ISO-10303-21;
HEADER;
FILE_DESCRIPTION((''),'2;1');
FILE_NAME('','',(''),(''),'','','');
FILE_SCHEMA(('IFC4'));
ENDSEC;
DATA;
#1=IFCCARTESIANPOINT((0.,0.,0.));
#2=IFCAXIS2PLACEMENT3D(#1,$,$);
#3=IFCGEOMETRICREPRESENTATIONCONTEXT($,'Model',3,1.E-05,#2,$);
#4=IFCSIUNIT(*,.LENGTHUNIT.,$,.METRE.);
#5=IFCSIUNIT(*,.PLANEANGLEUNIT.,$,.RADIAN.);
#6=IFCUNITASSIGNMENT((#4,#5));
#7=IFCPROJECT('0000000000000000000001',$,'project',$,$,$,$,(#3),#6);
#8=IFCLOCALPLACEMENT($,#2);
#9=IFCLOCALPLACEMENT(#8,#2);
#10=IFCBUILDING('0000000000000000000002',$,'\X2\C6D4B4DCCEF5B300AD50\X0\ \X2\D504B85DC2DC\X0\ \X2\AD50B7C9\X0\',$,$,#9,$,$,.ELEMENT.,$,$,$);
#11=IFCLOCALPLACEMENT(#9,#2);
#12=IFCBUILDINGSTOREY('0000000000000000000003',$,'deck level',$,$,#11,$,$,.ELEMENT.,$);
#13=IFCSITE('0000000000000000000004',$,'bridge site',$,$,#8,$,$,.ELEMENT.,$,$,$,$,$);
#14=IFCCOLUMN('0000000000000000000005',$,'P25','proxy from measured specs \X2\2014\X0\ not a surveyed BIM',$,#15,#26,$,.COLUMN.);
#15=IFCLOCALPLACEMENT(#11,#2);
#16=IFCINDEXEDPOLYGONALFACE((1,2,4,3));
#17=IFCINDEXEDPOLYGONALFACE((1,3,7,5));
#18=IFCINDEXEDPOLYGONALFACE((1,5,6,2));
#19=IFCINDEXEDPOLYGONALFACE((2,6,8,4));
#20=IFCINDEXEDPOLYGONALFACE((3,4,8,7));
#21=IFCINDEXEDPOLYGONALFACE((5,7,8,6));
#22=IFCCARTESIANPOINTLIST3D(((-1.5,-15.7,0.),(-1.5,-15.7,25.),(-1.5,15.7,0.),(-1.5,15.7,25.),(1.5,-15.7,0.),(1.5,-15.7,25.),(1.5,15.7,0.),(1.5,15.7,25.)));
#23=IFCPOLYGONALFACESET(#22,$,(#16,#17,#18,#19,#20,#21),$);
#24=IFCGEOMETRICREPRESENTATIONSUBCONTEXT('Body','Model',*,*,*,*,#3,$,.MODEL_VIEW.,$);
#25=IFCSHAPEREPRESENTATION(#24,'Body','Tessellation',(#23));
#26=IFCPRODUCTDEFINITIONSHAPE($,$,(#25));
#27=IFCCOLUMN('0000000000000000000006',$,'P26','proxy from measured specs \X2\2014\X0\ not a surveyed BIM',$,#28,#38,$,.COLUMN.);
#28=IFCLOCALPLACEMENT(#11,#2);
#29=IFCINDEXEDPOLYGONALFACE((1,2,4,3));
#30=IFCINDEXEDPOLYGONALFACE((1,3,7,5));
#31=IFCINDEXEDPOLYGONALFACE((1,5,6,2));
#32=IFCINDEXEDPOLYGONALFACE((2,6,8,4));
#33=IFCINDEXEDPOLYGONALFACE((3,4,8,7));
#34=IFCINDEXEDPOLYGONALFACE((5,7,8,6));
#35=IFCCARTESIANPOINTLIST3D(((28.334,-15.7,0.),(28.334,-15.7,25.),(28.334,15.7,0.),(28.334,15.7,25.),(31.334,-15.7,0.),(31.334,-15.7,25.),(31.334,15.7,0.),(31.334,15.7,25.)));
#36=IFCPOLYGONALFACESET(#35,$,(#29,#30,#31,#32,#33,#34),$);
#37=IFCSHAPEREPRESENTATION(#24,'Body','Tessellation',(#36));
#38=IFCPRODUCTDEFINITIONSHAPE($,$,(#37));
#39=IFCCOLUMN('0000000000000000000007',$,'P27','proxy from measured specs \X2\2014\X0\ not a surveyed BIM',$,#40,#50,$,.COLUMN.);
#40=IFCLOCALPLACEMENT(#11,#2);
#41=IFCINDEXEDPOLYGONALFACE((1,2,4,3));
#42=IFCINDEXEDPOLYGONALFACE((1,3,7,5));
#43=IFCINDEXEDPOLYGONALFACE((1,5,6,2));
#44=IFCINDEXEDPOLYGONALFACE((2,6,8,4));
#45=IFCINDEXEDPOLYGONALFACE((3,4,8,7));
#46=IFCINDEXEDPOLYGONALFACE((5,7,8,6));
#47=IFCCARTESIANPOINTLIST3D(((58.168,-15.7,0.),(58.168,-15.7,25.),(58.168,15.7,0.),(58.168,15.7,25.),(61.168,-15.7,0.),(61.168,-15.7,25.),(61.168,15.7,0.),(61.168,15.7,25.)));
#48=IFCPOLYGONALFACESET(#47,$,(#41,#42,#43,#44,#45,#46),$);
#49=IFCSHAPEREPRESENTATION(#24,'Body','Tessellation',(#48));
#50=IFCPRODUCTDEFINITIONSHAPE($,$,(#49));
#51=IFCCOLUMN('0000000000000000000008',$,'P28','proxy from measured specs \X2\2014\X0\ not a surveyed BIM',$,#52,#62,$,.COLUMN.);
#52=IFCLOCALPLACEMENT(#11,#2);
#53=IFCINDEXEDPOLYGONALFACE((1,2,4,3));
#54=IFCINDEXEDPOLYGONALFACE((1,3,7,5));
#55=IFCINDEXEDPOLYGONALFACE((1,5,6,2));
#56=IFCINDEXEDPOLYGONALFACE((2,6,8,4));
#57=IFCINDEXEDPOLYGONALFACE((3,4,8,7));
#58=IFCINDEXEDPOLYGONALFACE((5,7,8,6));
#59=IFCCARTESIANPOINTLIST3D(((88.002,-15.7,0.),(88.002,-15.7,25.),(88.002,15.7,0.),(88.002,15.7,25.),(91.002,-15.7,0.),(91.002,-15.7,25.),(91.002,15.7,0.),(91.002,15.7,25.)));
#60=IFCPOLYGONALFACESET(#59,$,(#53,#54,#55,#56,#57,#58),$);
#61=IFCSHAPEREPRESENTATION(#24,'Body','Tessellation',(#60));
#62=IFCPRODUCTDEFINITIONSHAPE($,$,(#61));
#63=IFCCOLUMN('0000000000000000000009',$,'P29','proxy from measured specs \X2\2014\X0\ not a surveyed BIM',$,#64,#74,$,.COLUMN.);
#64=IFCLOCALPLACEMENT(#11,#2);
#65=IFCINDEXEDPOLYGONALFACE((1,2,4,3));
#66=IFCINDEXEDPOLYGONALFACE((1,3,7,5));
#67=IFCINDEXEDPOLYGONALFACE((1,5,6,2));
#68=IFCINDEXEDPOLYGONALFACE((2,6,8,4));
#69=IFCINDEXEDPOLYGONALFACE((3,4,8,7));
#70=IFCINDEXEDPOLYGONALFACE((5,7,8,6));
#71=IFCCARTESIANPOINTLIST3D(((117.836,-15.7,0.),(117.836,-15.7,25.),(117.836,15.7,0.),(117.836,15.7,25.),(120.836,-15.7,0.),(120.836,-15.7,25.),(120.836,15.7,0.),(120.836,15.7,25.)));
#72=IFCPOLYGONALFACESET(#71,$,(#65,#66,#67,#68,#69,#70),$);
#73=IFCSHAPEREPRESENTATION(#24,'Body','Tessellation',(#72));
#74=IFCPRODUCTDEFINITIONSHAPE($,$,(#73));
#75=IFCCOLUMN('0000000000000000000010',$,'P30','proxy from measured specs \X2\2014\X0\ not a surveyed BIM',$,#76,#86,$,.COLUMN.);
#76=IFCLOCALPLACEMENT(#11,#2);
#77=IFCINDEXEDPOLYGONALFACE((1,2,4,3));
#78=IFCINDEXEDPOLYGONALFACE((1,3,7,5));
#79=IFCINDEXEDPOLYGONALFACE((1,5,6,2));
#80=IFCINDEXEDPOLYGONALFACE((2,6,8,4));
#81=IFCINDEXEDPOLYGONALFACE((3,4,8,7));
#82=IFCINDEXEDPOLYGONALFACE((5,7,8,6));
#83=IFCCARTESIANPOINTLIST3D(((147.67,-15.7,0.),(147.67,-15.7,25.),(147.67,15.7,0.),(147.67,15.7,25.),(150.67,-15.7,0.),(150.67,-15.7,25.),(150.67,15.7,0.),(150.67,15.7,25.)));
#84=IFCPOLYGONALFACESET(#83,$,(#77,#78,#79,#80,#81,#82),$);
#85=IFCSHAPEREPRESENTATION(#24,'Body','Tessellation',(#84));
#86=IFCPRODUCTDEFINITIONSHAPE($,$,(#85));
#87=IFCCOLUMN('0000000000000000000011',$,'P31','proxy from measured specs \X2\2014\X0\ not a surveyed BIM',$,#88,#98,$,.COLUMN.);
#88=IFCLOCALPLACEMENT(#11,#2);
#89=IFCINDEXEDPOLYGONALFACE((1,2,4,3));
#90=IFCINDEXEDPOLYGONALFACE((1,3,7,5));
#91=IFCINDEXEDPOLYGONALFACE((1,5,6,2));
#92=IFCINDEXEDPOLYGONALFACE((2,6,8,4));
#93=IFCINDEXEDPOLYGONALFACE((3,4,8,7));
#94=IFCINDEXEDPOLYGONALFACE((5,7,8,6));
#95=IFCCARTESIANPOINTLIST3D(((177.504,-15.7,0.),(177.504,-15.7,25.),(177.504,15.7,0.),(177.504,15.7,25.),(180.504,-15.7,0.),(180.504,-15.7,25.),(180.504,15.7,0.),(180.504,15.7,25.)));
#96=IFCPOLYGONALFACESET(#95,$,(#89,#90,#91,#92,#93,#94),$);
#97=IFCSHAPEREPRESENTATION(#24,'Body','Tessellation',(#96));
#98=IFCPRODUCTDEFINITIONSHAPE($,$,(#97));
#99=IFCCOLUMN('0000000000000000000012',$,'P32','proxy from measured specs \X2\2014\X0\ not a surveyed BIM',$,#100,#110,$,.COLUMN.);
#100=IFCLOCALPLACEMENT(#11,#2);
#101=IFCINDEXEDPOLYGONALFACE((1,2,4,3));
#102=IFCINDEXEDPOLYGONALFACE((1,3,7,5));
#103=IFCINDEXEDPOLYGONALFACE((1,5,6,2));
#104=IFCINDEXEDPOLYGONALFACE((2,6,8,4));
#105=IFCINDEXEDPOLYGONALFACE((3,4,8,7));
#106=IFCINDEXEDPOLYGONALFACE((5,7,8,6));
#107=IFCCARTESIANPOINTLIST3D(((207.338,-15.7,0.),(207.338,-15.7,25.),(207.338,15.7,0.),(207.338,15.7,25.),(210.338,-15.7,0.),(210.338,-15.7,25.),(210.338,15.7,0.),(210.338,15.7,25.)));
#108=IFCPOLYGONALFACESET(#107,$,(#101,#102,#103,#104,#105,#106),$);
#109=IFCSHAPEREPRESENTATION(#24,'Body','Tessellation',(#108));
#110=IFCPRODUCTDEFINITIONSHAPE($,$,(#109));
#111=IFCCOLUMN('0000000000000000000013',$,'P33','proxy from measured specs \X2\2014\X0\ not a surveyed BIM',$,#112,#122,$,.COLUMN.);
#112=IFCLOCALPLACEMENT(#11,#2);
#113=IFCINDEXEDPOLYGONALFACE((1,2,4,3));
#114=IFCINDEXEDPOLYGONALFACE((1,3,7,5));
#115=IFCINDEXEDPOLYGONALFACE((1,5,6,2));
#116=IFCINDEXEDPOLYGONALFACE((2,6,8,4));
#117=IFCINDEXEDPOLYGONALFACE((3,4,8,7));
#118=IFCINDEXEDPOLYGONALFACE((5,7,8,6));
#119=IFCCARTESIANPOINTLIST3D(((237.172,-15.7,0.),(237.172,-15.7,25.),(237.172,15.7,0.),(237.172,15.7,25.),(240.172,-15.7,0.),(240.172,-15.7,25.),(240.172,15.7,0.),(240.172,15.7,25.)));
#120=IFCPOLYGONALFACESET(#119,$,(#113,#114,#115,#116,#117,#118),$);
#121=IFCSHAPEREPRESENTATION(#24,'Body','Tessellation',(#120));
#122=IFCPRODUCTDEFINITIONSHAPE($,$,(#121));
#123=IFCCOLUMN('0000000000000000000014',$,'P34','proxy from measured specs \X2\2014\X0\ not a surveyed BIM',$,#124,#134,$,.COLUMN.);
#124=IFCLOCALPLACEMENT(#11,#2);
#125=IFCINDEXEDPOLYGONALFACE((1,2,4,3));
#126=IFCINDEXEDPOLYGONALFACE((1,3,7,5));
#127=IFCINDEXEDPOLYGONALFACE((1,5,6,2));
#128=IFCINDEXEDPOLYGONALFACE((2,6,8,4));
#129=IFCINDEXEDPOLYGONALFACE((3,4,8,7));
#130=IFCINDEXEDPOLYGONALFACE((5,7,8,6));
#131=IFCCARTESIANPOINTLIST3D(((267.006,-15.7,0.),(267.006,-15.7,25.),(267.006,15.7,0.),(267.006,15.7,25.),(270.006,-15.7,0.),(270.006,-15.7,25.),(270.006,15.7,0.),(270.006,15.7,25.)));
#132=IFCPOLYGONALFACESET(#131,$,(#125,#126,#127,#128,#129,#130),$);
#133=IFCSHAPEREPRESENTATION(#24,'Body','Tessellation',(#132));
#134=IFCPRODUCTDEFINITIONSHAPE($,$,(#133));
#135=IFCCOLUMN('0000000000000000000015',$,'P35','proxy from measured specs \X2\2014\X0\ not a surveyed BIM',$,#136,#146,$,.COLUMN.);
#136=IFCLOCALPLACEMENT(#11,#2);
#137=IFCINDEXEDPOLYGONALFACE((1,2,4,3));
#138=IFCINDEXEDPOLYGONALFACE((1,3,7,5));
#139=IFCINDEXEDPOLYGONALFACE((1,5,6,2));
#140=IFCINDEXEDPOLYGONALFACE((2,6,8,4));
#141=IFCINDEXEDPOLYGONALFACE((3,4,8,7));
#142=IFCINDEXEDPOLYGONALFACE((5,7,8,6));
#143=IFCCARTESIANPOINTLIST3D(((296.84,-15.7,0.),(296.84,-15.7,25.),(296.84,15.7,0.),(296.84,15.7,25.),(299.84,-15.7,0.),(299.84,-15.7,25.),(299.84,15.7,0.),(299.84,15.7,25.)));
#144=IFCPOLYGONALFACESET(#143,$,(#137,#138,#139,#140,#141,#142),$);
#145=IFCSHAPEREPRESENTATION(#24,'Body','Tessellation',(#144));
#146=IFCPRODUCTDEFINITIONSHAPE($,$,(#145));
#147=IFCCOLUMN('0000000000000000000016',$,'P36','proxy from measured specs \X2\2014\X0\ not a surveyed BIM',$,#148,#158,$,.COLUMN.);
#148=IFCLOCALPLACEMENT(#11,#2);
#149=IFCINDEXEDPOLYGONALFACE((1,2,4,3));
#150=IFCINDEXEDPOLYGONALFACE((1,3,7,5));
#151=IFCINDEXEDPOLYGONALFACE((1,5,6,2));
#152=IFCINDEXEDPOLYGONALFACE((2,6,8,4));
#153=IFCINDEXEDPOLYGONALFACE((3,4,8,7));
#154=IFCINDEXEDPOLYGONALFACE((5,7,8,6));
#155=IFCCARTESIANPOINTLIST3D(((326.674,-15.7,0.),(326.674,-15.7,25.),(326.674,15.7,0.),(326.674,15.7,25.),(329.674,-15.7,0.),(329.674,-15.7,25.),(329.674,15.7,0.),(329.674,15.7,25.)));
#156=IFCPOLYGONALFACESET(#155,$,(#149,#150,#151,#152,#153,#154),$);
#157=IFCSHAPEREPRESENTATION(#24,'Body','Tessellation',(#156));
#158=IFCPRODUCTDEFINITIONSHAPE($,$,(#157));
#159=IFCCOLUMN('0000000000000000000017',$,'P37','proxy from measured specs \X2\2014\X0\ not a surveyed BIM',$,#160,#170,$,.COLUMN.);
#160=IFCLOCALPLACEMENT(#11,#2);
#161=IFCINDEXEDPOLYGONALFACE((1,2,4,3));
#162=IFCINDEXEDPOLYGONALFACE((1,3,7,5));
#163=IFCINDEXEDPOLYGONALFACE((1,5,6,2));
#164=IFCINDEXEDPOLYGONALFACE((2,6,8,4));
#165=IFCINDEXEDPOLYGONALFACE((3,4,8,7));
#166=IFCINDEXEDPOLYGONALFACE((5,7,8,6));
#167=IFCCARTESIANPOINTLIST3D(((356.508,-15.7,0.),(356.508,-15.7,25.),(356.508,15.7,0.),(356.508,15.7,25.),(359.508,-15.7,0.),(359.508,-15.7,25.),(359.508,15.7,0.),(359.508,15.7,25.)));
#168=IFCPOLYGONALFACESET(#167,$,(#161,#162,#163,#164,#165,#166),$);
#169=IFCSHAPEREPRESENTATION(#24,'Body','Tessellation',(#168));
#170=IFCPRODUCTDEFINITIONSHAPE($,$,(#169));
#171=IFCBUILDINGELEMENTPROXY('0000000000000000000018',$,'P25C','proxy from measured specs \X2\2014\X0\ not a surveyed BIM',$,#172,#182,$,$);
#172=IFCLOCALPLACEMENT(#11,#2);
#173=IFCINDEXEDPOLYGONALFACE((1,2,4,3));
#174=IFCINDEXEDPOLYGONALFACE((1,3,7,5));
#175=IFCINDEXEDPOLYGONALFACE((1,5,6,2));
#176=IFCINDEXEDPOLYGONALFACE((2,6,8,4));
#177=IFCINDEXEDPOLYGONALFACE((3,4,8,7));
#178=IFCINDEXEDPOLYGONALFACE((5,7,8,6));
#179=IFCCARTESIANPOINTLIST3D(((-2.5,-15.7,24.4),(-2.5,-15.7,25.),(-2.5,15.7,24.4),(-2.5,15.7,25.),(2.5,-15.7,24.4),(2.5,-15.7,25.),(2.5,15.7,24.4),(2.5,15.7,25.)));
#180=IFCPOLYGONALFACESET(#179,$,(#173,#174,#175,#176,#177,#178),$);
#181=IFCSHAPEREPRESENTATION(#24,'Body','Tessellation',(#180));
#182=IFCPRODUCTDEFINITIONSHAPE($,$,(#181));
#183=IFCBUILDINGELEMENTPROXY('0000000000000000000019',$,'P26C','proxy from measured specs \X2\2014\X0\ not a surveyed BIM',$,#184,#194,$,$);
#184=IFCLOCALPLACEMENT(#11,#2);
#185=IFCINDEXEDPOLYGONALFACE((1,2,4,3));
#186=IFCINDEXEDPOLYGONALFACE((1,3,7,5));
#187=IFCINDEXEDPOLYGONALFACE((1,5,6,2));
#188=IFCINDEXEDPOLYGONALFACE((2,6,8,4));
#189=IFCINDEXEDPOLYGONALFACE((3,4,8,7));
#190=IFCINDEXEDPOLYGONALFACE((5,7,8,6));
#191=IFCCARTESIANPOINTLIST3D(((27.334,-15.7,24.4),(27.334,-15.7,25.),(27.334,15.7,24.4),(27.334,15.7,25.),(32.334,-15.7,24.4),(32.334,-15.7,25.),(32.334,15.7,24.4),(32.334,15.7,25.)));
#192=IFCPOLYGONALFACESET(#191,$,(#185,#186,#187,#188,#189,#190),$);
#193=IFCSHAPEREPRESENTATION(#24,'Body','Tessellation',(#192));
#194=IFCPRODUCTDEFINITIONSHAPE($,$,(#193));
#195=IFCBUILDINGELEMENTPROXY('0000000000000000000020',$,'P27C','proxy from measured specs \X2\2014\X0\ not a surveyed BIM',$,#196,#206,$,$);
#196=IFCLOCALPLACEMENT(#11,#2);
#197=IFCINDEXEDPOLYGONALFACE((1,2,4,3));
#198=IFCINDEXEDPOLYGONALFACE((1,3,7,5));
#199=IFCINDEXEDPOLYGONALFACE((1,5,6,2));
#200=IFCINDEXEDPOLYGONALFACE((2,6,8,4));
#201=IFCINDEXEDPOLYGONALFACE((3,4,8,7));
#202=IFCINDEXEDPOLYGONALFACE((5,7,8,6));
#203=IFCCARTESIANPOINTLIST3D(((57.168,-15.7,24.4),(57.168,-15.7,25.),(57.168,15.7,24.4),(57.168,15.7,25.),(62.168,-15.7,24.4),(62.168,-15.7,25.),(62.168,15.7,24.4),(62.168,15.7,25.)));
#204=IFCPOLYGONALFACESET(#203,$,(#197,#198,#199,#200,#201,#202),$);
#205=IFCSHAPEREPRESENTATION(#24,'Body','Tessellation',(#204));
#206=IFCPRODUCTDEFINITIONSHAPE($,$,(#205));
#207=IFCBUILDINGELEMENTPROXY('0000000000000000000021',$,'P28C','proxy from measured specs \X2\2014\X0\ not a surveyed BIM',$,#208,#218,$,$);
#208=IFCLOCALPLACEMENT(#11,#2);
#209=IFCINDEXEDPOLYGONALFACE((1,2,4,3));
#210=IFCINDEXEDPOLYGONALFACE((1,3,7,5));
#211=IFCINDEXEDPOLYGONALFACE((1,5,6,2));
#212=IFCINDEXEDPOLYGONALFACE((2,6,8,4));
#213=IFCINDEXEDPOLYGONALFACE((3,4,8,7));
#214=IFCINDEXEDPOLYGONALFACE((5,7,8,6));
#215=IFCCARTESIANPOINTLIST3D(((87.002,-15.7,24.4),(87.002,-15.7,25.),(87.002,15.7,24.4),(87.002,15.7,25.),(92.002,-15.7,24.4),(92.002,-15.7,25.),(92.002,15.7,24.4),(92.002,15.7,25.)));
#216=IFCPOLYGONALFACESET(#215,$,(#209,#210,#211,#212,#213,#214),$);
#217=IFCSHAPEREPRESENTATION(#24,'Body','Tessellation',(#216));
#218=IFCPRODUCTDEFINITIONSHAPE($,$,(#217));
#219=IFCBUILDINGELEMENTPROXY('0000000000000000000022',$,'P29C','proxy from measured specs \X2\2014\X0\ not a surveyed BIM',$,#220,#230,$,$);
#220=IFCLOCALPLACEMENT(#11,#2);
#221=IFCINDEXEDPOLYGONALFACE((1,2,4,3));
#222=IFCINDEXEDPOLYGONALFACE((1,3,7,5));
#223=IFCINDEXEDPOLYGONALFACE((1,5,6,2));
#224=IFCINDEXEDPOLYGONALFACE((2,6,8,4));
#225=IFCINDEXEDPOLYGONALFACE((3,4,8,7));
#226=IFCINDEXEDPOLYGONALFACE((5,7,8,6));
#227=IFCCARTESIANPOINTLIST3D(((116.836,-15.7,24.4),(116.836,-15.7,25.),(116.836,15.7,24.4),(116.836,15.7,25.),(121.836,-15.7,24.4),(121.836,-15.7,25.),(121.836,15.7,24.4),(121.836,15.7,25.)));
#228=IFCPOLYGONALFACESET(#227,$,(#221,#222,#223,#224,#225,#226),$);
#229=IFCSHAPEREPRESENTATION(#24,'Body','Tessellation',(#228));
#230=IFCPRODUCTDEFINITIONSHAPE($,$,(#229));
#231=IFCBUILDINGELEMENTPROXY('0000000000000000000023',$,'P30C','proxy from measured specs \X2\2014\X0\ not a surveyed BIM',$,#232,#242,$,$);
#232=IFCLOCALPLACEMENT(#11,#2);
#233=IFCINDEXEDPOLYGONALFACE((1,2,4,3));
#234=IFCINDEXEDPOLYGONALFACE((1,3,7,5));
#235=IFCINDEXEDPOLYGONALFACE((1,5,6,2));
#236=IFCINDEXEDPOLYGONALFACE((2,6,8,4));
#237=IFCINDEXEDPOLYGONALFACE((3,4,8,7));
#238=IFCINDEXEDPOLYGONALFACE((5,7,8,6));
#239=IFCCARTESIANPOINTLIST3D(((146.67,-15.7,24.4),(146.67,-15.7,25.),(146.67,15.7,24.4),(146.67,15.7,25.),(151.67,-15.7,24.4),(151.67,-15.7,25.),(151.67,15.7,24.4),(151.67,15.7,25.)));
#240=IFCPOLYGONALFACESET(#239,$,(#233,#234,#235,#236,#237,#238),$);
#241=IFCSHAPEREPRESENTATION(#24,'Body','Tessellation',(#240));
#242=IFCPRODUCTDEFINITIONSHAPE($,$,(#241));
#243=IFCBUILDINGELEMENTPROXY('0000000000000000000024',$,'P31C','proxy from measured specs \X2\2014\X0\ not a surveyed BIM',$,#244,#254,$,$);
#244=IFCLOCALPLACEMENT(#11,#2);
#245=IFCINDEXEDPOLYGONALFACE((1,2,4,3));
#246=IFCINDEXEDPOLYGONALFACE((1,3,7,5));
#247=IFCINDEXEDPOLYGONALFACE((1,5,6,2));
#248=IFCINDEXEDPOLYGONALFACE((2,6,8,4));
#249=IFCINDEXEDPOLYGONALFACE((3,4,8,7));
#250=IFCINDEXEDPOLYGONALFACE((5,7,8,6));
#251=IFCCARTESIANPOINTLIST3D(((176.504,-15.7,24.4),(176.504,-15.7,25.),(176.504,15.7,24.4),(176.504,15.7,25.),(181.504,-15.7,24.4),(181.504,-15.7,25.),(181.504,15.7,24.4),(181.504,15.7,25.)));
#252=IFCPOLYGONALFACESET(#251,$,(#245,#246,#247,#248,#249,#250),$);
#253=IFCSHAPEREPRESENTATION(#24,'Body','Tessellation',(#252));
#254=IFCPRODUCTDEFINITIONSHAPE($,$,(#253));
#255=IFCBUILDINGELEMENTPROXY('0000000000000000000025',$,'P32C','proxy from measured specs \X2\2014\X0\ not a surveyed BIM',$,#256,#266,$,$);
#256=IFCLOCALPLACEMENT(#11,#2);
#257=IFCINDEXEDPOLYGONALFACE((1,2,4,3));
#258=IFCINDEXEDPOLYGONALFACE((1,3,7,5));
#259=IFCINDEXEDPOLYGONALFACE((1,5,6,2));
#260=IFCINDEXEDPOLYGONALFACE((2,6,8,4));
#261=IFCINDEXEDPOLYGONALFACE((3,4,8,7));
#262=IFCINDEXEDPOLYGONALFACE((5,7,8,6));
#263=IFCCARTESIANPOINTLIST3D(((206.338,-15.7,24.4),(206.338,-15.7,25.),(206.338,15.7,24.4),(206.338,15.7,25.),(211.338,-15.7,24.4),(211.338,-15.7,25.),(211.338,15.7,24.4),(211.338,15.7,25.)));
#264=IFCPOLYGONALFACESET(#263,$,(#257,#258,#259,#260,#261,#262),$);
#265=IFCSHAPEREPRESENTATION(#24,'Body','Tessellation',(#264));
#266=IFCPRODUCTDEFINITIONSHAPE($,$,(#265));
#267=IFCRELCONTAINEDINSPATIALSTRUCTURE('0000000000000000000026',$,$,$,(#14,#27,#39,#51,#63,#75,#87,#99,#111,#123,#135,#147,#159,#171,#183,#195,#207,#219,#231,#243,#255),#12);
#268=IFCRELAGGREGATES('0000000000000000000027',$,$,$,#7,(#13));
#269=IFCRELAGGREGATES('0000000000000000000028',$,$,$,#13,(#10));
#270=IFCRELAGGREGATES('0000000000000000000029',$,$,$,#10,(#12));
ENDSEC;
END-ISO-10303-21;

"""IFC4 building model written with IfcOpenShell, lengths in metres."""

from ifc_helpers import new_model, si_unit, frame, origin, origin_2d, place, context, subcontext, project, spatial, rectangle, extrude, element, save


model = new_model("IFC4")

# Units and contexts
model_context = context("Model", 3, precision=1e-05, world=origin())
body_context = subcontext(model_context, "Body", "Model", "MODEL_VIEW")
ifc_project = project(units=[si_unit("LENGTHUNIT", "METRE"), si_unit("PLANEANGLEUNIT", "RADIAN")], contexts=[model_context])

# Site, building, storey
site_placement = place(None, origin())
site = spatial("IfcSite", under=ifc_project, at=site_placement, Name="bridge site", CompositionType="ELEMENT")
building_placement = place(site_placement, origin())
building = spatial("IfcBuilding", under=site, at=building_placement, Name="월드컵대교 프록시 교량", CompositionType="ELEMENT")
storey_placement = place(building_placement, origin())
storey = spatial("IfcBuildingStorey", under=building, at=storey_placement, Name="deck level", CompositionType="ELEMENT")

# Columns
for number, where, name in (
    (1, (0.0, 0.0, 0.0), "P25"),
    (2, (29.834, 0.0, 0.0), "P26"),
    (3, (59.668, 0.0, 0.0), "P27"),
    (4, (89.502, 0.0, 0.0), "P28"),
    (5, (119.336, 0.0, 0.0), "P29"),
    (6, (149.17, 0.0, 0.0), "P30"),
    (7, (179.004, 0.0, 0.0), "P31"),
    (8, (208.838, 0.0, 0.0), "P32"),
    (9, (238.672, 0.0, 0.0), "P33"),
    (10, (268.506, 0.0, 0.0), "P34"),
    (11, (298.34, 0.0, 0.0), "P35"),
    (12, (328.174, 0.0, 0.0), "P36"),
    (13, (358.008, 0.0, 0.0), "P37"),
):
    element("IfcColumn", number, at=place(storey_placement, frame(where)), inside=storey, Name=name, Description="proxy from measured specs — not a surveyed BIM", PredefinedType="COLUMN", context=body_context, shape_type="SweptSolid", body=[
        extrude(rectangle(XDim=3.0, YDim=31.4, at=origin_2d()), origin(), (0.0, 0.0, 1.0), 25.0),
    ])

# Building element proxies
for number, where, name in (
    (14, (0.0, 0.0, 24.4), "P25C"),
    (15, (29.834, 0.0, 24.4), "P26C"),
    (16, (59.668, 0.0, 24.4), "P27C"),
    (17, (89.502, 0.0, 24.4), "P28C"),
    (18, (119.336, 0.0, 24.4), "P29C"),
    (19, (149.17, 0.0, 24.4), "P30C"),
    (20, (179.004, 0.0, 24.4), "P31C"),
    (21, (208.838, 0.0, 24.4), "P32C"),
):
    element("IfcBuildingElementProxy", number, at=place(storey_placement, frame(where)), inside=storey, Name=name, Description="proxy from measured specs — not a surveyed BIM", context=body_context, shape_type="SweptSolid", body=[
        extrude(rectangle(XDim=5.0, YDim=31.4, at=origin_2d()), origin(), (0.0, 0.0, 1.0), 0.6),
    ])

save(model, "model.ifc")
